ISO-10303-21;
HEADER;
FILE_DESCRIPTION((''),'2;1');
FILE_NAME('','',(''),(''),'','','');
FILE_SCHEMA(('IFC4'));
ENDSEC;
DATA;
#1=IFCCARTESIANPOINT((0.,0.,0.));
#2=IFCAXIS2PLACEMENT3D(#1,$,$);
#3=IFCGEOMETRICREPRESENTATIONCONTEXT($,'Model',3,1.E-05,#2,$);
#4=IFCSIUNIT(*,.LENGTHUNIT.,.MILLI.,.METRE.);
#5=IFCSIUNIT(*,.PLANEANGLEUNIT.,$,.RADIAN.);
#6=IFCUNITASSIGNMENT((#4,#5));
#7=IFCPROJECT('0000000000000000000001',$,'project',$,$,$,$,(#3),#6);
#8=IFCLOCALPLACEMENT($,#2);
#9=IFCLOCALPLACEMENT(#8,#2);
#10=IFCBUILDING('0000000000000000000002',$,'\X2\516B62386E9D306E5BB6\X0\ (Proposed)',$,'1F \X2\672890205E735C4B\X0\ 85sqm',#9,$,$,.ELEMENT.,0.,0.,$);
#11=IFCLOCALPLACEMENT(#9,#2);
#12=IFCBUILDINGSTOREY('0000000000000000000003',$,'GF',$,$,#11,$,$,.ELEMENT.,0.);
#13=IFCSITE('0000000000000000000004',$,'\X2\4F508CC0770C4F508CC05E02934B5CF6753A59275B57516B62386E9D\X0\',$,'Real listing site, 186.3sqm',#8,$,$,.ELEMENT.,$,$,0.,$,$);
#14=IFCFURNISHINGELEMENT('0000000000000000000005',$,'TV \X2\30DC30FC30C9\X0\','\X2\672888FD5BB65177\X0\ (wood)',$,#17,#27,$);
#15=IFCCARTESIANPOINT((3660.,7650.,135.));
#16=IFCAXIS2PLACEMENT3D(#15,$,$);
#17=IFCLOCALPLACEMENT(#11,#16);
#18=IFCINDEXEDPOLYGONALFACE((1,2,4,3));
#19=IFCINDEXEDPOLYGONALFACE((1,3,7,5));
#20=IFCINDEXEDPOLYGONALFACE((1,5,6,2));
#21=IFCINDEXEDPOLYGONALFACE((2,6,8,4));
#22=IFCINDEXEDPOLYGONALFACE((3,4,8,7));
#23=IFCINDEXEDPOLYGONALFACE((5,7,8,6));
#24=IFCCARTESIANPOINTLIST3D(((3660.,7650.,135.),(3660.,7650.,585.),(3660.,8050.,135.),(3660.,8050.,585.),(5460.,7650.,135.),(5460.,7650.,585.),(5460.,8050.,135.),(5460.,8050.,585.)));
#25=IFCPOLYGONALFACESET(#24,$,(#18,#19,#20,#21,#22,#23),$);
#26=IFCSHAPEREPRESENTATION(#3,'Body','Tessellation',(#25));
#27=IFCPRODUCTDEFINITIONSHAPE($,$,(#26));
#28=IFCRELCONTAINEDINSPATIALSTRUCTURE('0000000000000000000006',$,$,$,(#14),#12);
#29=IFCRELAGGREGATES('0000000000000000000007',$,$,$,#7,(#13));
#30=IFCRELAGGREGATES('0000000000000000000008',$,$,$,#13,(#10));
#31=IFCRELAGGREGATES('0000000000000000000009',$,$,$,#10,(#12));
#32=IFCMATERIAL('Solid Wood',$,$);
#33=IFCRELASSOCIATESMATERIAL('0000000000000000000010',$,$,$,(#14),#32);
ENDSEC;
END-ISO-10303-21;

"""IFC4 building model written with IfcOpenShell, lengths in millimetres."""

from ifc_helpers import new_model, si_unit, frame, frame_2d, origin, place, context, project, spatial, rectangle, extrude, material, element, save


model = new_model("IFC4")

# Units and contexts
model_context = context("Model", 3, precision=1e-05, world=origin())
ifc_project = project(units=[si_unit("LENGTHUNIT", "METRE", prefix="MILLI"), si_unit("PLANEANGLEUNIT", "RADIAN")], contexts=[model_context])

# Site, building, storey
site_placement = place(None, origin())
site = spatial("IfcSite", under=ifc_project, at=site_placement, Name="佐賀県佐賀市鍋島町大字八戸溝", ObjectType="Real listing site, 186.3sqm", CompositionType="ELEMENT", RefElevation=0.0)
building_placement = place(site_placement, origin())
building = spatial("IfcBuilding", under=site, at=building_placement, Name="八戸溝の家 (Proposed)", ObjectType="1F 木造平屋 85sqm", CompositionType="ELEMENT", ElevationOfRefHeight=0.0, ElevationOfTerrain=0.0)
storey_placement = place(building_placement, origin())
storey = spatial("IfcBuildingStorey", under=building, at=storey_placement, Name="GF", CompositionType="ELEMENT", Elevation=0.0)

# Shared definitions
ifc_material_1 = material(Name="Solid Wood")

# Furnishing element
furnishing_1_placement = place(storey_placement, frame((3660.0, 7650.0, 135.0)))
element("IfcFurnishingElement", 1, at=furnishing_1_placement, inside=storey, material=ifc_material_1, Name="TV ボード", Description="木製家具 (wood)", context=model_context, shape_type="SweptSolid", body=[
    extrude(rectangle(XDim=1800.0, YDim=400.0, at=frame_2d((900.0, 200.0))), frame((3660.0, 7650.0, 135.0)), (0.0, 0.0, 1.0), 450.0),
])

save(model, "model.ifc")
